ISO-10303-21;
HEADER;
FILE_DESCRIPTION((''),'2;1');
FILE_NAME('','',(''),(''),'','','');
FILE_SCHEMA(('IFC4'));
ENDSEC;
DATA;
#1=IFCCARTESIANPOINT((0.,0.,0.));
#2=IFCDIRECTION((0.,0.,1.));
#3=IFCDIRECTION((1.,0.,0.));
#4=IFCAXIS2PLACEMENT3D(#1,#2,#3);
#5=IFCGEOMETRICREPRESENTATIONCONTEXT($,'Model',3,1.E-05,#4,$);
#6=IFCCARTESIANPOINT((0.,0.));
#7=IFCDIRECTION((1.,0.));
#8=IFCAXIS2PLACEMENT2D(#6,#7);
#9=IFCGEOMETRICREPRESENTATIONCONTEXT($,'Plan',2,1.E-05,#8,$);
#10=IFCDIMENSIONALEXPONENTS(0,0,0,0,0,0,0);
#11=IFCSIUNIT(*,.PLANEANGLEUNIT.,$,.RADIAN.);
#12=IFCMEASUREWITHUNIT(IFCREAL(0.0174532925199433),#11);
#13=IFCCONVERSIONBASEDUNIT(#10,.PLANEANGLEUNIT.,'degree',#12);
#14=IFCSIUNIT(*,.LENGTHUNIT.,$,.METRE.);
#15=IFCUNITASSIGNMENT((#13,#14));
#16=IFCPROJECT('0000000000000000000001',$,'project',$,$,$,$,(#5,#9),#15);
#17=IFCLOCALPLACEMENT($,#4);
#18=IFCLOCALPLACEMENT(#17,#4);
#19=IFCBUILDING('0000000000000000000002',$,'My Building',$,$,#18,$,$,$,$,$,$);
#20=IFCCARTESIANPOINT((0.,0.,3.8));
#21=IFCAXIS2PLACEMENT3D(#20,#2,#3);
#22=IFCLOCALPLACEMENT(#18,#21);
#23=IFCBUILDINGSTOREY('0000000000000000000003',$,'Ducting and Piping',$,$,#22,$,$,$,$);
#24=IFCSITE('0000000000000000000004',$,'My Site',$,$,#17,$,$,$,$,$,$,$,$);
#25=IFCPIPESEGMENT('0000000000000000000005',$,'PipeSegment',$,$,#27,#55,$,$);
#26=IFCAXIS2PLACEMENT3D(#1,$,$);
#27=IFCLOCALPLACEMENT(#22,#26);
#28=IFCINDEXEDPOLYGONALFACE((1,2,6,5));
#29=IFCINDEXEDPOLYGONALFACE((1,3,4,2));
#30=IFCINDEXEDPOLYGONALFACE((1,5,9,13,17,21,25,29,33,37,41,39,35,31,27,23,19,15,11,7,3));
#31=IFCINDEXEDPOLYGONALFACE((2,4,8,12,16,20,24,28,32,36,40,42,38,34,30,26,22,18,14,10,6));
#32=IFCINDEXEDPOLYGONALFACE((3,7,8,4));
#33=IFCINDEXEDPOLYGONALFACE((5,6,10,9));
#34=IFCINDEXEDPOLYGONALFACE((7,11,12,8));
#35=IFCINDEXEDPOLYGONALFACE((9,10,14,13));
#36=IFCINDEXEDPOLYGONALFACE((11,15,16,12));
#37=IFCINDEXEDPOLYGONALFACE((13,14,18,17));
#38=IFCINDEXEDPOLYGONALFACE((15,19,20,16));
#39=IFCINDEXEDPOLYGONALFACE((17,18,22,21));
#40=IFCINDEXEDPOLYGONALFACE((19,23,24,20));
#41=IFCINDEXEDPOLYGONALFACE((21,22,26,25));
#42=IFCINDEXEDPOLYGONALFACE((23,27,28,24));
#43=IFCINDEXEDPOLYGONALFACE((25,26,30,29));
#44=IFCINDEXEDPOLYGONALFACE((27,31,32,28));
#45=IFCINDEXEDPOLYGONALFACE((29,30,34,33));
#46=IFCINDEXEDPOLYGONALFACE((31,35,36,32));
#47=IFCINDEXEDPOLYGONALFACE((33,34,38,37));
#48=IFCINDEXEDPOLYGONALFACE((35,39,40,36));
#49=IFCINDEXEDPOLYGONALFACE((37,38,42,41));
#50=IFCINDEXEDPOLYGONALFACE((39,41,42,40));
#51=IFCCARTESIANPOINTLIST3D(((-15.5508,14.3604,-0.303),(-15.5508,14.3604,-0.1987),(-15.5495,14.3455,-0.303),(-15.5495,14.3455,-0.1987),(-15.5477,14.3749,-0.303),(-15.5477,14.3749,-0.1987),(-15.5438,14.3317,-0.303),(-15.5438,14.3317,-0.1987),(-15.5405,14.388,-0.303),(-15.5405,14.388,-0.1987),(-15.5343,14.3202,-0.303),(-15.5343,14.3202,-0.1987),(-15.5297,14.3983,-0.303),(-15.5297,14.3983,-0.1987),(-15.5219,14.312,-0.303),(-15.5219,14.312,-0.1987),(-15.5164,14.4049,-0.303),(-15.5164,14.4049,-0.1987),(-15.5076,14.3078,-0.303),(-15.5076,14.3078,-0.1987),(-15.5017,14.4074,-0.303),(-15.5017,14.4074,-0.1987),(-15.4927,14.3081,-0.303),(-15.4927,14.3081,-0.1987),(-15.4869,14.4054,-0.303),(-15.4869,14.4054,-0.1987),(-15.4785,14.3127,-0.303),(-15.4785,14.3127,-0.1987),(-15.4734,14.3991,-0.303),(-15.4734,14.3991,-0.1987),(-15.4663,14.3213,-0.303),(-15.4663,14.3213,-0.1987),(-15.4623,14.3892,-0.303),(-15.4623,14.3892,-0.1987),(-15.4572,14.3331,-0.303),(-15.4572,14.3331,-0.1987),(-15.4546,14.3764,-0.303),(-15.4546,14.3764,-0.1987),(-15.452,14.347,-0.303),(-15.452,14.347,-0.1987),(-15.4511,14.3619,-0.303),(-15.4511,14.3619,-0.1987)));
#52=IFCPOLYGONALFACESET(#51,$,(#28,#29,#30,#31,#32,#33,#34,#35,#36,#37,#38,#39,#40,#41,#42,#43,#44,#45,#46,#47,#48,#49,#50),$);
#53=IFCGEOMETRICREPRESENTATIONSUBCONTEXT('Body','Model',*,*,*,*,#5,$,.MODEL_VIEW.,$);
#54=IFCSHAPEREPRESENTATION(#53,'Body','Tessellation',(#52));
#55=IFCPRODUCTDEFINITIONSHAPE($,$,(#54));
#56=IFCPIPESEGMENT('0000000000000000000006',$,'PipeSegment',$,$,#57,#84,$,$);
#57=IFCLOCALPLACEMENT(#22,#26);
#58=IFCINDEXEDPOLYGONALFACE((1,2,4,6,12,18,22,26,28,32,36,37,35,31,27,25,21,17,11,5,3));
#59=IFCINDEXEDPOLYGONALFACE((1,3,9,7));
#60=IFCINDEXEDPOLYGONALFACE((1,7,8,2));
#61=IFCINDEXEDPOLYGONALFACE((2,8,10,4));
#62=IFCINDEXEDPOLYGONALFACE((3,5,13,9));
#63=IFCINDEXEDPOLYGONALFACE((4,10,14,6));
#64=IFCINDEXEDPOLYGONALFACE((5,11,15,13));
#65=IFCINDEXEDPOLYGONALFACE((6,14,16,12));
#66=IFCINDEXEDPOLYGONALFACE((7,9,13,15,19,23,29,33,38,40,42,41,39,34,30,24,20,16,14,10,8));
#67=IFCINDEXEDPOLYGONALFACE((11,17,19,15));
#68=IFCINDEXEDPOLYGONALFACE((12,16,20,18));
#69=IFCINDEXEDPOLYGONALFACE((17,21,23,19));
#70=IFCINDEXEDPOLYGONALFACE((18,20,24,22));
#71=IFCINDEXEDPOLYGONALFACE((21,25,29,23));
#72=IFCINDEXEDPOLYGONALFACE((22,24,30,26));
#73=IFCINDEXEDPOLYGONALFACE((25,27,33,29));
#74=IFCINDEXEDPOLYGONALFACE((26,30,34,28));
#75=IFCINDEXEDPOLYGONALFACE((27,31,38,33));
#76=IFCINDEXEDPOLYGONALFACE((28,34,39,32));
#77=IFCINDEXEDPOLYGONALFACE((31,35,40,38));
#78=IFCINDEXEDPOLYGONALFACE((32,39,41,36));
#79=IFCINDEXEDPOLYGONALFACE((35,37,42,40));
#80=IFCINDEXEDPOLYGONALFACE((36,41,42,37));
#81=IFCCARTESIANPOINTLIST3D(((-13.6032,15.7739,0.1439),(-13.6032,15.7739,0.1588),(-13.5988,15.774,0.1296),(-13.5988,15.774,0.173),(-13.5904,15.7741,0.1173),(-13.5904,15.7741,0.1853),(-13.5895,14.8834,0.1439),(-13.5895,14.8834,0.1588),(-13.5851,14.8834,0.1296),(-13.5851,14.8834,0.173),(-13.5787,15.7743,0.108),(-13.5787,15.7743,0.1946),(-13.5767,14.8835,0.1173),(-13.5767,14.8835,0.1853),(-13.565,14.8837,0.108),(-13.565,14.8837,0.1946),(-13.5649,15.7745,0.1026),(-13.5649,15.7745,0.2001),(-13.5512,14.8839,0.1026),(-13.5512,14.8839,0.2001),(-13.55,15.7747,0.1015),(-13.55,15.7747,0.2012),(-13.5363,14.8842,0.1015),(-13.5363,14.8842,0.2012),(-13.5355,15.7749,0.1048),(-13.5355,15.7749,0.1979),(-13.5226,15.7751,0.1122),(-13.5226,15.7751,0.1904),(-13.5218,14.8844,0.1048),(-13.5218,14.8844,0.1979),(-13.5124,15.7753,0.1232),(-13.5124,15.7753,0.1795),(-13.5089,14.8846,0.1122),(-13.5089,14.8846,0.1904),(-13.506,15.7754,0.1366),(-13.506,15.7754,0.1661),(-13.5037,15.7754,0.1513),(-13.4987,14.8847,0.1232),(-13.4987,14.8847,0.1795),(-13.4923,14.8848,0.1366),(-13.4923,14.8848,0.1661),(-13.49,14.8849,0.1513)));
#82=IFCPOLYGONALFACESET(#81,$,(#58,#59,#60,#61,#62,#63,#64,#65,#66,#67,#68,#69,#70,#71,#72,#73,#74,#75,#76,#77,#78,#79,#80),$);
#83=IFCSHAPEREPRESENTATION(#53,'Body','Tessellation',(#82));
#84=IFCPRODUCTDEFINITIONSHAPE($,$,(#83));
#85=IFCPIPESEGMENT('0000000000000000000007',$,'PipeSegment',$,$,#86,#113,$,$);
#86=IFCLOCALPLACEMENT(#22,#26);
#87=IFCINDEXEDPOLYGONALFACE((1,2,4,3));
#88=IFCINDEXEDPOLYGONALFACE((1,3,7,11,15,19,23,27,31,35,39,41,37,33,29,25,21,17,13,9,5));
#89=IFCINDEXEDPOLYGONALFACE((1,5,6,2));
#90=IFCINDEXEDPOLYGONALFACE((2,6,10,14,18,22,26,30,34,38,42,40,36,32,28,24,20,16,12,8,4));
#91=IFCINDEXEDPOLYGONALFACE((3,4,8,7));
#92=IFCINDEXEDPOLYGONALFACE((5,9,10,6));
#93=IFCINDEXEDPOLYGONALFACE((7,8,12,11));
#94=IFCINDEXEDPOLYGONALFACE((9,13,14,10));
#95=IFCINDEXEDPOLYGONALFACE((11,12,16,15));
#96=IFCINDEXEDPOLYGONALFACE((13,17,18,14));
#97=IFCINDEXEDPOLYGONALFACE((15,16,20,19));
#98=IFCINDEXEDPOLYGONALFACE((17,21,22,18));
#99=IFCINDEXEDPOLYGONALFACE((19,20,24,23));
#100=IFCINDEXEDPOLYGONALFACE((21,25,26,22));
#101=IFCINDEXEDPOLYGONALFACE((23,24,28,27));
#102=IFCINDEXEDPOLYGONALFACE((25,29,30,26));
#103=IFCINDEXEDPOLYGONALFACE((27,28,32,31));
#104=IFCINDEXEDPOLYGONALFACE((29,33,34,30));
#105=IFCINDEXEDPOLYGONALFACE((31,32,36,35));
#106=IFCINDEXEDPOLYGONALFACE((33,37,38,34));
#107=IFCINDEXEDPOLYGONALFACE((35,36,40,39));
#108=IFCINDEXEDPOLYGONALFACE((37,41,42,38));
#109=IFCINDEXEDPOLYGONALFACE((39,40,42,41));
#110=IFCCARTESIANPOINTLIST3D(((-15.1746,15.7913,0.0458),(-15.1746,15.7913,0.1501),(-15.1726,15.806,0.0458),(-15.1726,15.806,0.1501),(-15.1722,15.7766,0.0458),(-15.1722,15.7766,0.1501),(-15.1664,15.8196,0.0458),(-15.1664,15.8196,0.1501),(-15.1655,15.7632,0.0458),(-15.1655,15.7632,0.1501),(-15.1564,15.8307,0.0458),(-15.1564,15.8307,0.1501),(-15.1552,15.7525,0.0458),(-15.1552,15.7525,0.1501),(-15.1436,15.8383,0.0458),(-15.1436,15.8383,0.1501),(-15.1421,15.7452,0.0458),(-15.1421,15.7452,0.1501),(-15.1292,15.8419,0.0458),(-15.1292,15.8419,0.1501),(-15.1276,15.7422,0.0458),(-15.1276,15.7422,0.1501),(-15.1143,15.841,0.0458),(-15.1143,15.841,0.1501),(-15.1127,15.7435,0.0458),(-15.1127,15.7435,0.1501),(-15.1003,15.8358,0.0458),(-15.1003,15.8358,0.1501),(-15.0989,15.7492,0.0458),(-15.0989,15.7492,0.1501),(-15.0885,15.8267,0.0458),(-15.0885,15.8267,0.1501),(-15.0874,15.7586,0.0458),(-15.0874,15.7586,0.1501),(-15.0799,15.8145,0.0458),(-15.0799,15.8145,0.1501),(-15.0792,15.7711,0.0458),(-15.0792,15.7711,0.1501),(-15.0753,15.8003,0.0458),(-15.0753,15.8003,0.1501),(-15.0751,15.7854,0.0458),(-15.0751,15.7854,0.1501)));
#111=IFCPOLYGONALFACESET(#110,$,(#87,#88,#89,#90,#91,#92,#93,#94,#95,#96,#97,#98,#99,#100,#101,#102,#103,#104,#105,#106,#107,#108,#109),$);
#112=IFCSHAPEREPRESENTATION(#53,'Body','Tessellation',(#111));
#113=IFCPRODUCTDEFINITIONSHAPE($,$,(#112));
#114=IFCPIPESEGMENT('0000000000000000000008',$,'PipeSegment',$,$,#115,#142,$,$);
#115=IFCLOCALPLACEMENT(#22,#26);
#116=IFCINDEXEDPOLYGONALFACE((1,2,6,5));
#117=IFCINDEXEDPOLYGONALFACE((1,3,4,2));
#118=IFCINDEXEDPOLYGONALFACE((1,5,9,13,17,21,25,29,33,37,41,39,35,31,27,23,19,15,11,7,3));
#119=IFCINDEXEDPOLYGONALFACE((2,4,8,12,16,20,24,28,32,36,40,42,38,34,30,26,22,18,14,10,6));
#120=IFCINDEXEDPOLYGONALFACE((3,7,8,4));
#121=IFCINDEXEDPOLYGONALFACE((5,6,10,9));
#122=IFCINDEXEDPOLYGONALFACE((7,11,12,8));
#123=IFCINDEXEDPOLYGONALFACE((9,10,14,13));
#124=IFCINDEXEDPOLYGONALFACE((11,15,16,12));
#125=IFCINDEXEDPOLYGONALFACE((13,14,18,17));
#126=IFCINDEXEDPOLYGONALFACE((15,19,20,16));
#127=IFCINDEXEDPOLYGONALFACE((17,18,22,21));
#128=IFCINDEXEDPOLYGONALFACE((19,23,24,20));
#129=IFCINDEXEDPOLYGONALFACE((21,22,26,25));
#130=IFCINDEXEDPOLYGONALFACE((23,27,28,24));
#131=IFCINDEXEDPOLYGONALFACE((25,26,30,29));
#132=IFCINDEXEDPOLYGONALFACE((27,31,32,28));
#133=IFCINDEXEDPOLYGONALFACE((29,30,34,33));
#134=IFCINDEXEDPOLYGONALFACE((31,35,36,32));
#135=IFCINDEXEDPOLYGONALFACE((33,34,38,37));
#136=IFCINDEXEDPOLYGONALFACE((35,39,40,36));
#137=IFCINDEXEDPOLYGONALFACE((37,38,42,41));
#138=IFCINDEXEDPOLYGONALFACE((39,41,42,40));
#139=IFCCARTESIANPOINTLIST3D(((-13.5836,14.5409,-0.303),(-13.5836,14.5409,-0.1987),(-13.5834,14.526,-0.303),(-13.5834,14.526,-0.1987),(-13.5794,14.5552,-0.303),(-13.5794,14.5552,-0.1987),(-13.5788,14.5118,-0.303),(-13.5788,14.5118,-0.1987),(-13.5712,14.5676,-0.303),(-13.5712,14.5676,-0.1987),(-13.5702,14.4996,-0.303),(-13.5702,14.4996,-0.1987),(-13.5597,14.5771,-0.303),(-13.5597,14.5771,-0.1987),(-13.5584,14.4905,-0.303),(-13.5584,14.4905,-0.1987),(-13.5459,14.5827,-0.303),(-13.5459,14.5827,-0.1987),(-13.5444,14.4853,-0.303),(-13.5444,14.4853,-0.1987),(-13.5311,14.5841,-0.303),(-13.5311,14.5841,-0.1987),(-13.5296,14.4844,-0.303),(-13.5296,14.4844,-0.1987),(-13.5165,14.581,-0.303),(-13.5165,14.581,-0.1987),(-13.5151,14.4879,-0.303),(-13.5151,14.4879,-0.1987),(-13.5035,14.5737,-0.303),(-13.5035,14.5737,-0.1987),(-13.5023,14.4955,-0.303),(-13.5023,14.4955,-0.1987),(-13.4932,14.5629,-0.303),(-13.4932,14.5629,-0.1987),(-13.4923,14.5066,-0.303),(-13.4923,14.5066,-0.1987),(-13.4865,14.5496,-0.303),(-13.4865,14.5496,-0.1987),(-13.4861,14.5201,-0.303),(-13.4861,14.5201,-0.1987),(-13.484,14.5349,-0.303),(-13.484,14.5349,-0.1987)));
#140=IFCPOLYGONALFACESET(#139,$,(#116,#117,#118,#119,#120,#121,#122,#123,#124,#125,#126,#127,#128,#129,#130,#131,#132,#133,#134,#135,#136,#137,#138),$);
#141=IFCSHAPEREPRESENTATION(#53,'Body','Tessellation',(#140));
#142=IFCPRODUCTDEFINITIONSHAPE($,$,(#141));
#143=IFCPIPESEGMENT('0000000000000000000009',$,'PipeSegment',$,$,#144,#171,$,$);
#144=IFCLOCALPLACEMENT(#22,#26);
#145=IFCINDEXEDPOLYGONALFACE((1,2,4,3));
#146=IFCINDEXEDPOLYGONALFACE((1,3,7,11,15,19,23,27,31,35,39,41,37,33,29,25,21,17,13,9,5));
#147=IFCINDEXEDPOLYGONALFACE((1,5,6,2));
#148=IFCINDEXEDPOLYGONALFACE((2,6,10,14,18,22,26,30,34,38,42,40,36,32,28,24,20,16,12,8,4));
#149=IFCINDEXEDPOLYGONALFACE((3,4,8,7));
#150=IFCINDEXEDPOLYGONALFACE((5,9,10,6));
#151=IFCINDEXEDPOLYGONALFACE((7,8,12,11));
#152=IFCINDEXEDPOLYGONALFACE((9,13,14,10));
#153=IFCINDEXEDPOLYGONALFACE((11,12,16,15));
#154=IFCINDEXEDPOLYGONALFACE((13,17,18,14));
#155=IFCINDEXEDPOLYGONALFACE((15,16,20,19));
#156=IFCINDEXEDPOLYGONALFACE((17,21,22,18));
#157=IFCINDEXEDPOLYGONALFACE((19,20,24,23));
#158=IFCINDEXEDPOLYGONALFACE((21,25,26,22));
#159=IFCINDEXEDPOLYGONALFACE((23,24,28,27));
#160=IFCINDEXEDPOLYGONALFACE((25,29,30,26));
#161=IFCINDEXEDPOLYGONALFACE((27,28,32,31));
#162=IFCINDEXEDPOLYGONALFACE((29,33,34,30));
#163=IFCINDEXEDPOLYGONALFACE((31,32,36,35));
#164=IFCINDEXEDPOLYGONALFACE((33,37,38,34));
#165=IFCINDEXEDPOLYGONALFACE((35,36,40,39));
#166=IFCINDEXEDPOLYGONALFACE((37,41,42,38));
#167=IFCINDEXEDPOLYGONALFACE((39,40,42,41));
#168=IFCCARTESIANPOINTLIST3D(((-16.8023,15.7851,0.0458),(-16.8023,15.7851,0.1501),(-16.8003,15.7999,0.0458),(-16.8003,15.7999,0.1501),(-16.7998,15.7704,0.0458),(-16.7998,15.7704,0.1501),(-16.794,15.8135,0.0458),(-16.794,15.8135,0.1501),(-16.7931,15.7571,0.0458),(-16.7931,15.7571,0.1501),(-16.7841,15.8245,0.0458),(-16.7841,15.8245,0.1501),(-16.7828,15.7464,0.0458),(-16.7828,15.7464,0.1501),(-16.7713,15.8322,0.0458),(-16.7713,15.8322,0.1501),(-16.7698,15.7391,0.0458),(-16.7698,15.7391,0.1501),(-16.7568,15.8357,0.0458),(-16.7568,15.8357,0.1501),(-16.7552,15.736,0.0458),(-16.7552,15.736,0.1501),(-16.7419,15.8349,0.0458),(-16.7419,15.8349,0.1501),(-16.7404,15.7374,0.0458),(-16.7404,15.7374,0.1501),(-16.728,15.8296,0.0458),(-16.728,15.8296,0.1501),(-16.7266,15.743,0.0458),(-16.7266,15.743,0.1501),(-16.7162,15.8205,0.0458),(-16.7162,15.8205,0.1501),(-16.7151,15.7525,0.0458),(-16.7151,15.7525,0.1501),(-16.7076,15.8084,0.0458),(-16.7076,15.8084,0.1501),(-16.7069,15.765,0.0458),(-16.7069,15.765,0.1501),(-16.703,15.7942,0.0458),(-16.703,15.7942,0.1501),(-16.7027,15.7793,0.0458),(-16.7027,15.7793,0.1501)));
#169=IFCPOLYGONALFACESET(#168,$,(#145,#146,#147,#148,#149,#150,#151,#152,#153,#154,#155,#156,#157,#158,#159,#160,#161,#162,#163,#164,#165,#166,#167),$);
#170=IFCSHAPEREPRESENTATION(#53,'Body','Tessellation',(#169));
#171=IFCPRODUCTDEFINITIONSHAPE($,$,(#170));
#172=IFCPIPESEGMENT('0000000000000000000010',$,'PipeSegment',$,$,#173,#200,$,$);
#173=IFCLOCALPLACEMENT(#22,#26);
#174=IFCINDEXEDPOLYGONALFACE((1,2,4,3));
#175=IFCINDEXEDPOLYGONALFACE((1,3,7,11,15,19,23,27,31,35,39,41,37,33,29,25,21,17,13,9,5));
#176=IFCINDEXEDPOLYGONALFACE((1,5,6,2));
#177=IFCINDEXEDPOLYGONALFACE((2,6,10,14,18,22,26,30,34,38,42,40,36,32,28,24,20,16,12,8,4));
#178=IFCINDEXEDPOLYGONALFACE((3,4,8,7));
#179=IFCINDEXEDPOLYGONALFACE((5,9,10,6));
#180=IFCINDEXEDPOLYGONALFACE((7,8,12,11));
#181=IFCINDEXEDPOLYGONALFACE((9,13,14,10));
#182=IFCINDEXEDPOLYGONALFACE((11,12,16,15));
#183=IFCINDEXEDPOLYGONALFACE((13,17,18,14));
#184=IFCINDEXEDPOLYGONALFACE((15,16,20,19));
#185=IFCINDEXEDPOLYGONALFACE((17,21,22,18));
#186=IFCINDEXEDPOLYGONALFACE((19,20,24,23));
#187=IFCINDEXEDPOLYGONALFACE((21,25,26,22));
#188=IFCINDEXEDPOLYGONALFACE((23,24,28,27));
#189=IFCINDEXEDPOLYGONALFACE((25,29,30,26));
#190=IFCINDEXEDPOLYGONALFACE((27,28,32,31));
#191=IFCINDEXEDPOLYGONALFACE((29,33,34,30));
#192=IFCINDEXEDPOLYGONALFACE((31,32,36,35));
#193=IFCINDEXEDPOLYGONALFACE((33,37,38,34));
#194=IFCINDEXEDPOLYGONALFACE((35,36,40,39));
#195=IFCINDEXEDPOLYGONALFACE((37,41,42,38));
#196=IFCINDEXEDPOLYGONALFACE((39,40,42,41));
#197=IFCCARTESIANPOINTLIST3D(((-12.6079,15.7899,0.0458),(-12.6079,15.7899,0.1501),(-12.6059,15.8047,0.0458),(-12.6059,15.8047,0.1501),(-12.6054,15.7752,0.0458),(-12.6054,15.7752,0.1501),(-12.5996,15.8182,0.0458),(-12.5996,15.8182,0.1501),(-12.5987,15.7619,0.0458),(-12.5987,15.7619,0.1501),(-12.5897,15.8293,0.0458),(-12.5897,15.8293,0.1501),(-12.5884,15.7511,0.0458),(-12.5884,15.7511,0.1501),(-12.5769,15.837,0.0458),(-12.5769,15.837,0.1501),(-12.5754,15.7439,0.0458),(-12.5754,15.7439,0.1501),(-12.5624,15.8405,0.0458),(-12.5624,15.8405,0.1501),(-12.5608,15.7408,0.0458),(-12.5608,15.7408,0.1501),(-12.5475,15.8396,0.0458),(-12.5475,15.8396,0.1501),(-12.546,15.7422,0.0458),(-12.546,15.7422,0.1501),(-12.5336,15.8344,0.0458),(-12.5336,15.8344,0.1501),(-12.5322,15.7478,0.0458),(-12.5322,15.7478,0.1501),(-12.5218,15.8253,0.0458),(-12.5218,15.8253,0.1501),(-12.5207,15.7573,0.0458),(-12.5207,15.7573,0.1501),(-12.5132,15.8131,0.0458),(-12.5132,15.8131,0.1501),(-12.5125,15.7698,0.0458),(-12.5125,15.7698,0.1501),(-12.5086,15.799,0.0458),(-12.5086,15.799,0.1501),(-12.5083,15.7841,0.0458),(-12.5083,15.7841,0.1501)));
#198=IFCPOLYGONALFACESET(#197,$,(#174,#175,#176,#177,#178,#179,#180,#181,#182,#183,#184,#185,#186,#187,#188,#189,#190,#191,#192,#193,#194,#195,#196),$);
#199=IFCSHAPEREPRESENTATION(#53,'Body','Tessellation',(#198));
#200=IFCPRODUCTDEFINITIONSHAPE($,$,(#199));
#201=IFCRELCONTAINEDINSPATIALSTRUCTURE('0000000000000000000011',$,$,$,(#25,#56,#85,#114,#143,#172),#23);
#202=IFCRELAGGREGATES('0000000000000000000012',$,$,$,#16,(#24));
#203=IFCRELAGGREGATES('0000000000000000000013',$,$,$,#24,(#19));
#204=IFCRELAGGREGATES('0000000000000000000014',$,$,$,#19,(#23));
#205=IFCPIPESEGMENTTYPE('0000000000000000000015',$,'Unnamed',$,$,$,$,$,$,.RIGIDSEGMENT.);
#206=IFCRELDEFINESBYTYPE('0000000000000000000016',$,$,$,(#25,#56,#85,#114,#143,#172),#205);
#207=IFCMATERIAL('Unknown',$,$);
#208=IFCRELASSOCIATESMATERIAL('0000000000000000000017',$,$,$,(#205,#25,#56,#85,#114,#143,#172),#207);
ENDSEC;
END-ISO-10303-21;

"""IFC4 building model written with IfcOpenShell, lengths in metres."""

from ifc_helpers import new_model, entity, si_unit, converted_unit, frame, origin_with_axes, origin_2d_with_axis, place, context, subcontext, project, spatial, circle, extrude, material, material_profile, profile_set, profile_usage, type_object, element, save


model = new_model("IFC4")

# Units and contexts
model_context = context("Model", 3, precision=1e-05, world=origin_with_axes())
plan_context = context("Plan", 2, precision=1e-05, world=origin_2d_with_axis())
body_context = subcontext(model_context, "Body", "Model", "MODEL_VIEW")
ifc_project = project(units=[converted_unit("PLANEANGLEUNIT", "degree", entity("IfcReal", 0.0174532925199433), si_unit("PLANEANGLEUNIT", "RADIAN"), dimensions=[0, 0, 0, 0, 0, 0, 0]), si_unit("LENGTHUNIT", "METRE")], contexts=[model_context, plan_context])

# Site, building, storey
site_placement = place(None, origin_with_axes())
site = spatial("IfcSite", under=ifc_project, at=site_placement, Name="My Site")
building_placement = place(site_placement, origin_with_axes())
building = spatial("IfcBuilding", under=site, at=building_placement, Name="My Building")
storey_placement = place(building_placement, frame((0.0, 0.0, 3.8), z_axis=(0.0, 0.0, 1.0), x_axis=(1.0, 0.0, 0.0)))
storey = spatial("IfcBuildingStorey", under=building, at=storey_placement, Name="Ducting and Piping")

# Pipe segments
ifc_material = material(Name="Unknown")
ifc_material_profile_1 = material_profile(ifc_material, circle(Radius=0.05))
ifc_profile_set_1 = profile_set([ifc_material_profile_1])
pipe_segment_type = type_object("IfcPipeSegmentType", Name="Unnamed", PredefinedType="RIGIDSEGMENT", material=ifc_profile_set_1)
ifc_profile_usage_1 = profile_usage(ifc_profile_set_1, cardinal=5)
pipe_segment_1_placement = place(storey_placement, frame((-15.5009, 14.3574, -0.303), z_axis=(0.0, 0.0, 1.0), x_axis=(-0.015371, 0.999882, 0.0)))
element("IfcPipeSegment", 1, at=pipe_segment_1_placement, inside=storey, type_object=pipe_segment_type, material=ifc_profile_usage_1, Name="PipeSegment", context=body_context, shape_type="SweptSolid", body=[
    extrude(circle(Radius=0.05), origin_with_axes(), (0.0, 0.0, 1.0), 0.1043),
])
ifc_profile_usage_2 = profile_usage(ifc_profile_set_1, cardinal=5)
pipe_segment_2_placement = place(storey_placement, frame((-13.5537, 15.7747, 0.1513), z_axis=(0.015385, -0.999882, 0.0), x_axis=(0.999882, 0.015385, 0.0)))
element("IfcPipeSegment", 2, at=pipe_segment_2_placement, inside=storey, type_object=pipe_segment_type, material=ifc_profile_usage_2, Name="PipeSegment", context=body_context, shape_type="SweptSolid", body=[
    extrude(circle(Radius=0.05), origin_with_axes(), (0.0, 0.0, 1.0), 0.8907),
])
ifc_profile_usage_3 = profile_usage(ifc_profile_set_1, cardinal=5)
pipe_segment_3_placement = place(storey_placement, frame((-15.1246, 15.7921, 0.0458), z_axis=(0.0, 0.0, 1.0), x_axis=(-0.999873, -0.015924, 0.0)))
element("IfcPipeSegment", 3, at=pipe_segment_3_placement, inside=storey, type_object=pipe_segment_type, material=ifc_profile_usage_3, Name="PipeSegment", context=body_context, shape_type="SweptSolid", body=[
    extrude(circle(Radius=0.05), origin_with_axes(), (0.0, 0.0, 1.0), 0.1043),
])
ifc_profile_usage_4 = profile_usage(ifc_profile_set_1, cardinal=5)
pipe_segment_4_placement = place(storey_placement, frame((-13.534, 14.5342, -0.303), z_axis=(0.0, 0.0, 1.0), x_axis=(0.999889, 0.014879, 0.0)))
element("IfcPipeSegment", 4, at=pipe_segment_4_placement, inside=storey, type_object=pipe_segment_type, material=ifc_profile_usage_4, Name="PipeSegment", context=body_context, shape_type="SweptSolid", body=[
    extrude(circle(Radius=0.05), origin_with_axes(), (0.0, 0.0, 1.0), 0.1043),
])
ifc_profile_usage_5 = profile_usage(ifc_profile_set_1, cardinal=5)
pipe_segment_5_placement = place(storey_placement, frame((-16.7523, 15.7859, 0.0458), z_axis=(0.0, 0.0, 1.0), x_axis=(-0.999873, -0.015924, 0.0)))
element("IfcPipeSegment", 5, at=pipe_segment_5_placement, inside=storey, type_object=pipe_segment_type, material=ifc_profile_usage_5, Name="PipeSegment", context=body_context, shape_type="SweptSolid", body=[
    extrude(circle(Radius=0.05), origin_with_axes(), (0.0, 0.0, 1.0), 0.1043),
])
ifc_profile_usage_6 = profile_usage(ifc_profile_set_1, cardinal=5)
pipe_segment_6_placement = place(storey_placement, frame((-12.5579, 15.7907, 0.0458), z_axis=(0.0, 0.0, 1.0), x_axis=(-0.999873, -0.015924, 0.0)))
element("IfcPipeSegment", 6, at=pipe_segment_6_placement, inside=storey, type_object=pipe_segment_type, material=ifc_profile_usage_6, Name="PipeSegment", context=body_context, shape_type="SweptSolid", body=[
    extrude(circle(Radius=0.05), origin_with_axes(), (0.0, 0.0, 1.0), 0.1043),
])

save(model, "model.ifc")
